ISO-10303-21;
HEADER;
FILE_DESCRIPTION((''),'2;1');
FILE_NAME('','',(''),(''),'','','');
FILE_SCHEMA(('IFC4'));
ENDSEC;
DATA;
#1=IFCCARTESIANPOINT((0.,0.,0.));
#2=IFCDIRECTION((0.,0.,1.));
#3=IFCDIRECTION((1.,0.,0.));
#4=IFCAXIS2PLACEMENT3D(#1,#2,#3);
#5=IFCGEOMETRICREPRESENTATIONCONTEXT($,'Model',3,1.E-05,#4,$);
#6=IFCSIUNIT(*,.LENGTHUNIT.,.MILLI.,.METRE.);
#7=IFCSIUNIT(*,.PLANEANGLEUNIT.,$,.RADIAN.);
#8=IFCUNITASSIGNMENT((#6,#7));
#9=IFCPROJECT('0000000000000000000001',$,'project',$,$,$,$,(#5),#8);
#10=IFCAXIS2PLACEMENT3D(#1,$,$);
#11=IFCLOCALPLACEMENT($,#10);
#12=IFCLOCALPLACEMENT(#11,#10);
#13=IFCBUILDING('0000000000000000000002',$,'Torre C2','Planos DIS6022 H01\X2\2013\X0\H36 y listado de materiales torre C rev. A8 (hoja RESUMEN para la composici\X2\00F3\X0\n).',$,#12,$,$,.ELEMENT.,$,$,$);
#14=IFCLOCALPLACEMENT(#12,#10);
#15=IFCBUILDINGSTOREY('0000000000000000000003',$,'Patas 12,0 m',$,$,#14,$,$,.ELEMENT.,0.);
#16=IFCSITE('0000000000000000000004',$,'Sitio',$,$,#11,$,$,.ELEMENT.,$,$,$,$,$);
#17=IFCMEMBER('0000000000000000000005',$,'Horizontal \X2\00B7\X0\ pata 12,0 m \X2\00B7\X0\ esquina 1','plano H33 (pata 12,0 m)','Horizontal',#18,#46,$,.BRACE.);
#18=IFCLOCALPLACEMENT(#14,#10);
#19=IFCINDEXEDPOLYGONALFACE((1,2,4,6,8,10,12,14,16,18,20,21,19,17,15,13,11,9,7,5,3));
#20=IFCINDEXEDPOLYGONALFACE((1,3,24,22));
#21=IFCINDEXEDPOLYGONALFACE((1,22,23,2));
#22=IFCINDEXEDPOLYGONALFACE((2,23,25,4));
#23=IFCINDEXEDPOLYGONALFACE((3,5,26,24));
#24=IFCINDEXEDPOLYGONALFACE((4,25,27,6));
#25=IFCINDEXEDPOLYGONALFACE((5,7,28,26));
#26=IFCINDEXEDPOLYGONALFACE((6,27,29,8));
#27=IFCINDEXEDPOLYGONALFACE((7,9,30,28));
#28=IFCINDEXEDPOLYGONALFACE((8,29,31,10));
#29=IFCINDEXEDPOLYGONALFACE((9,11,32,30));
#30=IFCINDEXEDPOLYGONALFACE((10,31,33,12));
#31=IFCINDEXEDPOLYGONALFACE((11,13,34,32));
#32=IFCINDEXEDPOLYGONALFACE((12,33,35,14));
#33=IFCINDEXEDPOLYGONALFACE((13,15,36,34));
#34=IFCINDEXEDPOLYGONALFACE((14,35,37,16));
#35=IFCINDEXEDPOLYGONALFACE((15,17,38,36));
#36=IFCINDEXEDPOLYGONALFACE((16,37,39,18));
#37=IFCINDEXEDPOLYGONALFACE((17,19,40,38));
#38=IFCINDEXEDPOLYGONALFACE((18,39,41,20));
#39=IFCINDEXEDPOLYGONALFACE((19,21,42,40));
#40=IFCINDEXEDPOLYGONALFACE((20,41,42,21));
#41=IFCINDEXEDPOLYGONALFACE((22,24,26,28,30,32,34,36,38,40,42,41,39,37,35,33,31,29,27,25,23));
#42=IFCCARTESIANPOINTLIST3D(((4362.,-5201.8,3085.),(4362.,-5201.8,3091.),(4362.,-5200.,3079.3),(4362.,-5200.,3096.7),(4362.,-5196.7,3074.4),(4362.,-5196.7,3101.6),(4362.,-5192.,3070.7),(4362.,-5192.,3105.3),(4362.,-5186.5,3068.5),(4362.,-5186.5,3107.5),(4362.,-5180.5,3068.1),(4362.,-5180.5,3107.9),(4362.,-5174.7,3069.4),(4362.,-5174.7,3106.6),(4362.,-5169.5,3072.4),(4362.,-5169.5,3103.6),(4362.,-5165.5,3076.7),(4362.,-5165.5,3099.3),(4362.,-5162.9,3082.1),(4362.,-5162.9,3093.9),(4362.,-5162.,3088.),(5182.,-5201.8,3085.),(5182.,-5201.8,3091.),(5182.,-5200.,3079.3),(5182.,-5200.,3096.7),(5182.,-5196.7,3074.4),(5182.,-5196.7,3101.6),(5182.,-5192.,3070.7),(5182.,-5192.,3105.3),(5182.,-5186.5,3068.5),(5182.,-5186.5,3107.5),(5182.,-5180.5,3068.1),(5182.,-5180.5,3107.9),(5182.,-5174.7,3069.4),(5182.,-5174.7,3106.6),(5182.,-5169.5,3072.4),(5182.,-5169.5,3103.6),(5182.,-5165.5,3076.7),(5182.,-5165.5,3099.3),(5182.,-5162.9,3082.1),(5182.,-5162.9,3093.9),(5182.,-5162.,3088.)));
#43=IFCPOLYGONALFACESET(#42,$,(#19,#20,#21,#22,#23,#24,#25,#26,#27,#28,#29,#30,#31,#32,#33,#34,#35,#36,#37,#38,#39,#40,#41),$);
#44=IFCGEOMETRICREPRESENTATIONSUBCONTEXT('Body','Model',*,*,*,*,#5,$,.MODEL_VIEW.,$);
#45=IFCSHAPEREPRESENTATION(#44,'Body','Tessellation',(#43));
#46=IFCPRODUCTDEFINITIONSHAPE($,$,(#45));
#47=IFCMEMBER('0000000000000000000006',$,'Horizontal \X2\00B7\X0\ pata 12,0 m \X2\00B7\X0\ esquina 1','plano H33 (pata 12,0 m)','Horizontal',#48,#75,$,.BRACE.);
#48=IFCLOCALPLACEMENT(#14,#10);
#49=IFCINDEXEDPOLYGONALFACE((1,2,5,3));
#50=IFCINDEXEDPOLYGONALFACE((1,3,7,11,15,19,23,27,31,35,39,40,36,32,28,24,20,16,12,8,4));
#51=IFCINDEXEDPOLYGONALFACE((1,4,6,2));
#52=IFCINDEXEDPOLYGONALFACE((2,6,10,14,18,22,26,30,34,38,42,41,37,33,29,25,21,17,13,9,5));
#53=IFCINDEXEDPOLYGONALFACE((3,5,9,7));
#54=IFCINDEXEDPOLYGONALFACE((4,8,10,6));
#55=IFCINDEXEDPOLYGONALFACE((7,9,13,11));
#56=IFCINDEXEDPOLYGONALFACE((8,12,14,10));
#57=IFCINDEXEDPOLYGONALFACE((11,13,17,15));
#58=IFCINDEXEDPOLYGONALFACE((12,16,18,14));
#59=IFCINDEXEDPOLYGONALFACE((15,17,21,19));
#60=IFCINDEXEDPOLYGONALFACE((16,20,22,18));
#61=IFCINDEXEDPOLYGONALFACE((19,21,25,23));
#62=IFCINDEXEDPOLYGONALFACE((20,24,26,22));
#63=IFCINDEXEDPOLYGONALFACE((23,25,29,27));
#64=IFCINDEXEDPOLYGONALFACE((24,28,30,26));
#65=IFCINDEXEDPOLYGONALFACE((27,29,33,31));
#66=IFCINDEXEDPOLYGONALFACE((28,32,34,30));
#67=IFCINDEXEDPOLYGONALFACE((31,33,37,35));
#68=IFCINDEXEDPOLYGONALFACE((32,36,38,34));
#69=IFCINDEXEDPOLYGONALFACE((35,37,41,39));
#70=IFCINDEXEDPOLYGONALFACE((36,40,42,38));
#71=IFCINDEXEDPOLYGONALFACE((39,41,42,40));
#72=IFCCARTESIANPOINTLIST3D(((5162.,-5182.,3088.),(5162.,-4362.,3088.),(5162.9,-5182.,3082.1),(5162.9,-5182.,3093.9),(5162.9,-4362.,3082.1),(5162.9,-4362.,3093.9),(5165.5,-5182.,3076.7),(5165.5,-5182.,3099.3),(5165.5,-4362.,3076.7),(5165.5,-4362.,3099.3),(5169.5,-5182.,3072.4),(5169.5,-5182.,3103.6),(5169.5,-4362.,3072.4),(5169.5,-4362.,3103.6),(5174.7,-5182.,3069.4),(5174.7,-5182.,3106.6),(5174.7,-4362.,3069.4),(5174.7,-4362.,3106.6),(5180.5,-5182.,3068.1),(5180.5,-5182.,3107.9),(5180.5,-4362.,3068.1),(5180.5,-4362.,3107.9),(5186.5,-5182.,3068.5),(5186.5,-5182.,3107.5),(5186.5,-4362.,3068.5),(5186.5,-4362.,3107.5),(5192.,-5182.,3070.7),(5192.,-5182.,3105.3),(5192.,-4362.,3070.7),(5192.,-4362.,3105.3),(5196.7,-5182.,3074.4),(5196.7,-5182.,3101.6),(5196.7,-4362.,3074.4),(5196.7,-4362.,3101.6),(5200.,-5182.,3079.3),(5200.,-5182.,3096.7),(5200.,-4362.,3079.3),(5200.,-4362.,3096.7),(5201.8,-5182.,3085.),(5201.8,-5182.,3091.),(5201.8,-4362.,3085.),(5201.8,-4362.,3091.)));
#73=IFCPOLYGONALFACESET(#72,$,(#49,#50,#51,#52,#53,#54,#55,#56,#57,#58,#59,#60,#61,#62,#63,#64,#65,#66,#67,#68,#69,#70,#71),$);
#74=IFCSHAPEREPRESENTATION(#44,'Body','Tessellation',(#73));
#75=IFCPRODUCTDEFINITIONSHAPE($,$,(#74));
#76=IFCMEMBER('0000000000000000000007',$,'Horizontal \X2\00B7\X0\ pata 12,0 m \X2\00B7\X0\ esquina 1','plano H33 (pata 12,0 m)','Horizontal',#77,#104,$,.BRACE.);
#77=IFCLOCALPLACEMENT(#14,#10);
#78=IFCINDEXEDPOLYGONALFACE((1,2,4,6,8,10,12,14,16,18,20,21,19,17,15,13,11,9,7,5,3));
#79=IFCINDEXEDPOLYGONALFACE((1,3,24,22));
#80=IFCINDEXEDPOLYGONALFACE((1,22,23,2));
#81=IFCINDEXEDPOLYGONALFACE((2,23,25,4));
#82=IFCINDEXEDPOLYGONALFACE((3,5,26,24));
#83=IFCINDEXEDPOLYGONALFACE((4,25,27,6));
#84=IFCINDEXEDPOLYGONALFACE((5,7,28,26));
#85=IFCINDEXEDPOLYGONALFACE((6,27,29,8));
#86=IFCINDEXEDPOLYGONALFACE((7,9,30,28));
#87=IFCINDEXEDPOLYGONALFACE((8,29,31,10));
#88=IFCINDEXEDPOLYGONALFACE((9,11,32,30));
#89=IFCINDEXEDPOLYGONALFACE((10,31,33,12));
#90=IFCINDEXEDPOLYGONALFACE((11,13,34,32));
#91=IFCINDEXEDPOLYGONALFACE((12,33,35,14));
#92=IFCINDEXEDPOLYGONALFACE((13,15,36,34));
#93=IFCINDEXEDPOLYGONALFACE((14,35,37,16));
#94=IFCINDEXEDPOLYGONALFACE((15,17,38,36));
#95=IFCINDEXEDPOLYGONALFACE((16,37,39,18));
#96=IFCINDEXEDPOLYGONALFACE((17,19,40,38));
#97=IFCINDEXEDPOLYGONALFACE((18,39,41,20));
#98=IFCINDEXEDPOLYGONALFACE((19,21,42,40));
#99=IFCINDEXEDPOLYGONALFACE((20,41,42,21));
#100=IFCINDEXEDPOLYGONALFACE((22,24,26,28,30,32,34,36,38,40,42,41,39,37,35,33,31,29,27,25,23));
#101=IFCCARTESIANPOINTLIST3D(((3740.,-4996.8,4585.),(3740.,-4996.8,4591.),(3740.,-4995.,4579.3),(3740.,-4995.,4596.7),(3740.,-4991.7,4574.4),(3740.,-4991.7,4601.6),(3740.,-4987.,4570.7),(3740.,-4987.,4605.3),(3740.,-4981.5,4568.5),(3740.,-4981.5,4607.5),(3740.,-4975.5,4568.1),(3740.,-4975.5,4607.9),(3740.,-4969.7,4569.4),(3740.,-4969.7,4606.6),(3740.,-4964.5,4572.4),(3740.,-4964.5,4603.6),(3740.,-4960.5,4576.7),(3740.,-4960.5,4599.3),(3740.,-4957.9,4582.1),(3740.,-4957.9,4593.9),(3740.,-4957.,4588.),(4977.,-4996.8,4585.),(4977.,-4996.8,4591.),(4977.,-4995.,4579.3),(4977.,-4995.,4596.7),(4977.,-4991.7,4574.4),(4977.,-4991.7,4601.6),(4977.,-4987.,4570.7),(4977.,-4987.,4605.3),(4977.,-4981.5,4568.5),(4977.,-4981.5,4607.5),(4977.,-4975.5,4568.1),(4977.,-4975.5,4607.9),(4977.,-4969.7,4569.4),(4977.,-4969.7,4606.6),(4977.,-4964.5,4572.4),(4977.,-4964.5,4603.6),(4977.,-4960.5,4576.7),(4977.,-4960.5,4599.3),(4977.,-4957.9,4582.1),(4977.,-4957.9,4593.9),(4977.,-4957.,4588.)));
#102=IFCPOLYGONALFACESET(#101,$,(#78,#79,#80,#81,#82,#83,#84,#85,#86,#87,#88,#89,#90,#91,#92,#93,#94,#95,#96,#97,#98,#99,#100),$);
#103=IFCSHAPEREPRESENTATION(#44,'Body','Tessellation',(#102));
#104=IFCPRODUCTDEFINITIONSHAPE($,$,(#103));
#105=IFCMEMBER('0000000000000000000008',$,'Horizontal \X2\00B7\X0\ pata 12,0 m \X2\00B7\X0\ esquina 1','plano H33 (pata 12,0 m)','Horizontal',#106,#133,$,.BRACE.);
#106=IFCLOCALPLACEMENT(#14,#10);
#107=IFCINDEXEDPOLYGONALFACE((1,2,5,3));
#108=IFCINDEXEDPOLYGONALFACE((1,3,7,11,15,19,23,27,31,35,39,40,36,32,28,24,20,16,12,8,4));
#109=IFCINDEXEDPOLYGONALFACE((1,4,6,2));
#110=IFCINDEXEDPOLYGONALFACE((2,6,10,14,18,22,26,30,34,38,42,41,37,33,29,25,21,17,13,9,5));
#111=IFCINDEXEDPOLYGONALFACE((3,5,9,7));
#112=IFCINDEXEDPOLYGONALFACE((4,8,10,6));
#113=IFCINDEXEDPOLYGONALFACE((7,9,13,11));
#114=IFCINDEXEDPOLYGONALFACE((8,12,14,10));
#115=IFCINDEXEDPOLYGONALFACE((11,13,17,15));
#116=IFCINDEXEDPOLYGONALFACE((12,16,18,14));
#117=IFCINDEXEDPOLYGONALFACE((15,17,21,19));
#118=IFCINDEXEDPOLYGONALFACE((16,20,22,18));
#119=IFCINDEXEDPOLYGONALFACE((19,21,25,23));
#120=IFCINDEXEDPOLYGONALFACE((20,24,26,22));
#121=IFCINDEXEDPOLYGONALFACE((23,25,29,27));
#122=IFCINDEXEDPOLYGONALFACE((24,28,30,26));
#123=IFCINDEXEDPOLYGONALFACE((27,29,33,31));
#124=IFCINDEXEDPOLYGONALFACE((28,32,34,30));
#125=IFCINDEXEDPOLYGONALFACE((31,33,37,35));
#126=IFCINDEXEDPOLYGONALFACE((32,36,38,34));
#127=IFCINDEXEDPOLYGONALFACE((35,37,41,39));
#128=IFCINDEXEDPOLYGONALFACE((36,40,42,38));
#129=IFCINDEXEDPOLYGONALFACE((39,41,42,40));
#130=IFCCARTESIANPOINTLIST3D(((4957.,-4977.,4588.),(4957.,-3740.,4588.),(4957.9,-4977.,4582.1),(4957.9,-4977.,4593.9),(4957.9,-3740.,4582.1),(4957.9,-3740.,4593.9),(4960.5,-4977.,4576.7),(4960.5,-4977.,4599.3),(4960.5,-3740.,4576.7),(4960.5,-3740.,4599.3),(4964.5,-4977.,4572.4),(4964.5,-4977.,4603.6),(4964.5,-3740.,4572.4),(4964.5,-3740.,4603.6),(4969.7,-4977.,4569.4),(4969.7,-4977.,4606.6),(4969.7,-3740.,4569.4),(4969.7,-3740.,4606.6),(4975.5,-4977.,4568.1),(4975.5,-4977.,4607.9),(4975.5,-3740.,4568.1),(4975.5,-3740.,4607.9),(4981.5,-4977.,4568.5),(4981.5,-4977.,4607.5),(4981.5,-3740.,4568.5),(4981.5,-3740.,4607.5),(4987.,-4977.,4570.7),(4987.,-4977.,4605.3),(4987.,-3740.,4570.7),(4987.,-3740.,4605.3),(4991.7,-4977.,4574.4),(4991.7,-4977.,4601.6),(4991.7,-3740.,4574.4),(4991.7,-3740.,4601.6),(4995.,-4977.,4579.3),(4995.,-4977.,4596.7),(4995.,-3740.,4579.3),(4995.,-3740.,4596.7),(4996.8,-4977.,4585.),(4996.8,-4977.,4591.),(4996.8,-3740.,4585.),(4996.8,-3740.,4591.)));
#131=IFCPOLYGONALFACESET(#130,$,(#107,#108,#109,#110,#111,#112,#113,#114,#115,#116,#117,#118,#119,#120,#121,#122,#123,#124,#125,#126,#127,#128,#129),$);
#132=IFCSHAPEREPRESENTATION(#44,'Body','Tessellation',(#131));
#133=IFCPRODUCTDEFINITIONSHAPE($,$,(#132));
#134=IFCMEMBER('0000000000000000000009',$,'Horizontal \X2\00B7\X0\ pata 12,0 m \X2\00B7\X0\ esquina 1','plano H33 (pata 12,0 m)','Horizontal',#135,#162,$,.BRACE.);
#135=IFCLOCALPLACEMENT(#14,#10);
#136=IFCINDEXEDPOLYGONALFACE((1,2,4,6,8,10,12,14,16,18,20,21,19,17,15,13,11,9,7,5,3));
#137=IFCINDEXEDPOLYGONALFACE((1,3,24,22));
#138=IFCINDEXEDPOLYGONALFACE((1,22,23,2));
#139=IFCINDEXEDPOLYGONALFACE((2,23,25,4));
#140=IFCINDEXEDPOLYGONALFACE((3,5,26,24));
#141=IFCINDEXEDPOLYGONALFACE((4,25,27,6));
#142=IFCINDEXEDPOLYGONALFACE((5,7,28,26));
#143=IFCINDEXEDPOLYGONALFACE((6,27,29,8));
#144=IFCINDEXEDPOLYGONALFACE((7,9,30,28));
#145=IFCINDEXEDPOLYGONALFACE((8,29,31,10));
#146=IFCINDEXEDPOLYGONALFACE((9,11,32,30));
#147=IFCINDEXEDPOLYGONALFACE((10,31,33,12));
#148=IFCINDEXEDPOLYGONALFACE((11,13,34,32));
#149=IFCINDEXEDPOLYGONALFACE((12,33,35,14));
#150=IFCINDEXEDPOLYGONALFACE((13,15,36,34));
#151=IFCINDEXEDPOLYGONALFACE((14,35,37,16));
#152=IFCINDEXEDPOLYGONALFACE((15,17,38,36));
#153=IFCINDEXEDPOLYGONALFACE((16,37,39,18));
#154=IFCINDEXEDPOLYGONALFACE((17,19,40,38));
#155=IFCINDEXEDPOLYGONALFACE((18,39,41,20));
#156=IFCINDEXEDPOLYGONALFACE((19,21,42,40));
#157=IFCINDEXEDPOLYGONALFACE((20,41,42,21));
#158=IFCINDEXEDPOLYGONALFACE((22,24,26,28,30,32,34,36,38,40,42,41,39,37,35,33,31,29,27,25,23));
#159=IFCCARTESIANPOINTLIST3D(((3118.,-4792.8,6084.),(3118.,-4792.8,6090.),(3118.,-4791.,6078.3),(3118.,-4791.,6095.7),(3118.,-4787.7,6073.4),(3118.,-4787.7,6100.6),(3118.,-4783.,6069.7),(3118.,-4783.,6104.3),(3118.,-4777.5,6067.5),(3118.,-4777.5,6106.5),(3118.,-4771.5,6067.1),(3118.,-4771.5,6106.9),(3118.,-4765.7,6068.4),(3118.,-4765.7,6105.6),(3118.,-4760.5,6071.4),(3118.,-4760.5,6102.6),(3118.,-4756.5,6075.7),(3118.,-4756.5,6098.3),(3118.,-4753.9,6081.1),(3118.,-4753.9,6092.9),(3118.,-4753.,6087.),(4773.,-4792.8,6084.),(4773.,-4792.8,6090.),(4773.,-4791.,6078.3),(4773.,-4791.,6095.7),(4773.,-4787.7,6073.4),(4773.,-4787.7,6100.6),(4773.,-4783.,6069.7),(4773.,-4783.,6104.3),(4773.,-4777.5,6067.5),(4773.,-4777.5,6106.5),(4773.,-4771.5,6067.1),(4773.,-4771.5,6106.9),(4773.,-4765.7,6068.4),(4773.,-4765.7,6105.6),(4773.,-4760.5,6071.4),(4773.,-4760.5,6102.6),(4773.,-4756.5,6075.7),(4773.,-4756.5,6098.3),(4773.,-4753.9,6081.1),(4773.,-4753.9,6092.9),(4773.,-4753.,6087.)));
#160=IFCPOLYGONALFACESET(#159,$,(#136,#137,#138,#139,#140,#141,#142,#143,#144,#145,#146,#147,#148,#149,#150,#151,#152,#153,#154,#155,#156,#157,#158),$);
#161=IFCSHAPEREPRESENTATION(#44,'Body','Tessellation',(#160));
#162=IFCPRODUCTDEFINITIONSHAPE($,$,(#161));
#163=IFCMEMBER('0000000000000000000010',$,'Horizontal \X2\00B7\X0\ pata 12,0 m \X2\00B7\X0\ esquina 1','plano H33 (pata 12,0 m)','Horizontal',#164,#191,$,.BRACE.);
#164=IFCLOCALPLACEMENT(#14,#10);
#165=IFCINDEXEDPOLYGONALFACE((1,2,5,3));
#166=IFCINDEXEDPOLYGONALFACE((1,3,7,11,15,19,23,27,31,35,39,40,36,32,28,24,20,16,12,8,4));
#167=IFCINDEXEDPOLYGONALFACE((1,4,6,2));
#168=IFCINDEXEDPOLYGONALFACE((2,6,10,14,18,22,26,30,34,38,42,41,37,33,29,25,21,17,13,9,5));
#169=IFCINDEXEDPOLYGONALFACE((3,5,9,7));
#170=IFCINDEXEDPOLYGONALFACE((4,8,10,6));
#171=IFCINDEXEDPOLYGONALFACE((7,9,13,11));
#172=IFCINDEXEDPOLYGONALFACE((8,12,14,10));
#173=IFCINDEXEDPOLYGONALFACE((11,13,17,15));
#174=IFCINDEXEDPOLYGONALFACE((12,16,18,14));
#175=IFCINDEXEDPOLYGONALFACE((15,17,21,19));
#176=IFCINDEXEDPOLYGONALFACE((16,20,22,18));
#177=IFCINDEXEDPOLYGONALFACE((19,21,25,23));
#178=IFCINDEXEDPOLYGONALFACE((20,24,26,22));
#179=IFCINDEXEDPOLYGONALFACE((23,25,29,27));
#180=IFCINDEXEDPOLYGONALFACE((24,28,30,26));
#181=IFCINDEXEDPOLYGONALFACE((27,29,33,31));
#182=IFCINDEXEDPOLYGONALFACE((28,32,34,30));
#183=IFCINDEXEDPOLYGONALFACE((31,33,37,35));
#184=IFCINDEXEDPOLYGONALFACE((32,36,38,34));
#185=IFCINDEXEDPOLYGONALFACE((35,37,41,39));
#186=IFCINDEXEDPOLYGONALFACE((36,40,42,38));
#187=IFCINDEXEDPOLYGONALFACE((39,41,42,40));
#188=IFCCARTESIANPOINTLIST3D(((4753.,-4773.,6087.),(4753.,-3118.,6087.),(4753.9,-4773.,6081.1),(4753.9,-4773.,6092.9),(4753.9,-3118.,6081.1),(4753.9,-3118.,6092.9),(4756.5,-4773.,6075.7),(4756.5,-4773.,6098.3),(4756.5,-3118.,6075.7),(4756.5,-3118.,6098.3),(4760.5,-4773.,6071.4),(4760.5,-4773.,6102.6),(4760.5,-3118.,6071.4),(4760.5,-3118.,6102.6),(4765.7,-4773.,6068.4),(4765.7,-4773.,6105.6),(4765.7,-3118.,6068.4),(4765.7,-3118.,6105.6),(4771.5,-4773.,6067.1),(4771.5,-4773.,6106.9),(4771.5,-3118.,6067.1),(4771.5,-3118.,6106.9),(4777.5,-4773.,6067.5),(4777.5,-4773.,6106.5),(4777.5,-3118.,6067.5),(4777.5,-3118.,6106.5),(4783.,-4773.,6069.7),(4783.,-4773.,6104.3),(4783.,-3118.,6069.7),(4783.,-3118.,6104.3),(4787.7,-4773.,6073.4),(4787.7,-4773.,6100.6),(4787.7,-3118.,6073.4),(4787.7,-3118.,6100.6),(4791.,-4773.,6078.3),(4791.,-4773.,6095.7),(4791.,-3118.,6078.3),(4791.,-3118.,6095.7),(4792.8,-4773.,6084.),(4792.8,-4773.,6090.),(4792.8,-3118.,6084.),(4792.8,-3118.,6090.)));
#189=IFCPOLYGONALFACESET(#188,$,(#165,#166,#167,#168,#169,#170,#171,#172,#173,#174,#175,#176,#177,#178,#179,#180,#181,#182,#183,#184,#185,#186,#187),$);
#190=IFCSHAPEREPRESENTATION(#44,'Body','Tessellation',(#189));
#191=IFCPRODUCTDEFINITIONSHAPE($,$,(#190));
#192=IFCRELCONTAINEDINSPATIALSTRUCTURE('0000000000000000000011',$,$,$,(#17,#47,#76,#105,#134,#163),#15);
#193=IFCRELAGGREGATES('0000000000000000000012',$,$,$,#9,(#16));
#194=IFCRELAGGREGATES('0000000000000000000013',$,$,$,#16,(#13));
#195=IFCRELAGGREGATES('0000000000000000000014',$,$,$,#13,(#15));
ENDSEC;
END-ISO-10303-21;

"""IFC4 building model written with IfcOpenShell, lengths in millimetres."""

from ifc_helpers import new_model, si_unit, frame, origin, origin_with_axes, place, context, subcontext, project, spatial, circle, extrude, element, save


model = new_model("IFC4")

# Units and contexts
model_context = context("Model", 3, precision=1e-05, world=origin_with_axes())
body_context = subcontext(model_context, "Body", "Model", "MODEL_VIEW")
ifc_project = project(units=[si_unit("LENGTHUNIT", "METRE", prefix="MILLI"), si_unit("PLANEANGLEUNIT", "RADIAN")], contexts=[model_context])

# Site, building, storey
site_placement = place(None, origin())
site = spatial("IfcSite", under=ifc_project, at=site_placement, Name="Sitio", CompositionType="ELEMENT")
building_placement = place(site_placement, origin())
building = spatial("IfcBuilding", under=site, at=building_placement, Name="Torre C2", Description="Planos DIS6022 H01–H36 y listado de materiales torre C rev. A8 (hoja RESUMEN para la composición).", CompositionType="ELEMENT")
storey_placement = place(building_placement, origin())
storey = spatial("IfcBuildingStorey", under=building, at=storey_placement, Name="Patas 12,0 m", CompositionType="ELEMENT", Elevation=0.0)

# Members
for number, where, z_axis, x_axis, name in (
    (1, (5182.0, -5182.0, 3088.0), (-1.0, 0.0, 0.0), (0.0, 1.0, 0.0), "Horizontal · pata 12,0 m · esquina 1"),
    (2, (5182.0, -5182.0, 3088.0), (0.0, 1.0, 0.0), (-1.0, 0.0, 0.0), "Horizontal · pata 12,0 m · esquina 1"),
):
    element("IfcMember", number, at=place(storey_placement, frame(where, z_axis=z_axis, x_axis=x_axis)), inside=storey, Name=name, Description="plano H33 (pata 12,0 m)", ObjectType="Horizontal", PredefinedType="BRACE", context=body_context, shape_type="SweptSolid", body=[
        extrude(circle(Radius=20.0), None, (0.0, 0.0, 1.0), 820.0),
    ])
for number, where, z_axis, x_axis, name in (
    (3, (4977.0, -4977.0, 4588.0), (-1.0, 0.0, 0.0), (0.0, 1.0, 0.0), "Horizontal · pata 12,0 m · esquina 1"),
    (4, (4977.0, -4977.0, 4588.0), (0.0, 1.0, 0.0), (-1.0, 0.0, 0.0), "Horizontal · pata 12,0 m · esquina 1"),
):
    element("IfcMember", number, at=place(storey_placement, frame(where, z_axis=z_axis, x_axis=x_axis)), inside=storey, Name=name, Description="plano H33 (pata 12,0 m)", ObjectType="Horizontal", PredefinedType="BRACE", context=body_context, shape_type="SweptSolid", body=[
        extrude(circle(Radius=20.0), None, (0.0, 0.0, 1.0), 1237.0),
    ])
for number, where, z_axis, x_axis, name in (
    (5, (3118.0, -4773.0, 6087.0), (1.0, 0.0, 0.0), (0.0, 1.0, 0.0), "Horizontal · pata 12,0 m · esquina 1"),
    (6, (4773.0, -3118.0, 6087.0), (0.0, -1.0, 0.0), (-1.0, 0.0, 0.0), "Horizontal · pata 12,0 m · esquina 1"),
):
    element("IfcMember", number, at=place(storey_placement, frame(where, z_axis=z_axis, x_axis=x_axis)), inside=storey, Name=name, Description="plano H33 (pata 12,0 m)", ObjectType="Horizontal", PredefinedType="BRACE", context=body_context, shape_type="SweptSolid", body=[
        extrude(circle(Radius=20.0), None, (0.0, 0.0, 1.0), 1655.0),
    ])

save(model, "model.ifc")
